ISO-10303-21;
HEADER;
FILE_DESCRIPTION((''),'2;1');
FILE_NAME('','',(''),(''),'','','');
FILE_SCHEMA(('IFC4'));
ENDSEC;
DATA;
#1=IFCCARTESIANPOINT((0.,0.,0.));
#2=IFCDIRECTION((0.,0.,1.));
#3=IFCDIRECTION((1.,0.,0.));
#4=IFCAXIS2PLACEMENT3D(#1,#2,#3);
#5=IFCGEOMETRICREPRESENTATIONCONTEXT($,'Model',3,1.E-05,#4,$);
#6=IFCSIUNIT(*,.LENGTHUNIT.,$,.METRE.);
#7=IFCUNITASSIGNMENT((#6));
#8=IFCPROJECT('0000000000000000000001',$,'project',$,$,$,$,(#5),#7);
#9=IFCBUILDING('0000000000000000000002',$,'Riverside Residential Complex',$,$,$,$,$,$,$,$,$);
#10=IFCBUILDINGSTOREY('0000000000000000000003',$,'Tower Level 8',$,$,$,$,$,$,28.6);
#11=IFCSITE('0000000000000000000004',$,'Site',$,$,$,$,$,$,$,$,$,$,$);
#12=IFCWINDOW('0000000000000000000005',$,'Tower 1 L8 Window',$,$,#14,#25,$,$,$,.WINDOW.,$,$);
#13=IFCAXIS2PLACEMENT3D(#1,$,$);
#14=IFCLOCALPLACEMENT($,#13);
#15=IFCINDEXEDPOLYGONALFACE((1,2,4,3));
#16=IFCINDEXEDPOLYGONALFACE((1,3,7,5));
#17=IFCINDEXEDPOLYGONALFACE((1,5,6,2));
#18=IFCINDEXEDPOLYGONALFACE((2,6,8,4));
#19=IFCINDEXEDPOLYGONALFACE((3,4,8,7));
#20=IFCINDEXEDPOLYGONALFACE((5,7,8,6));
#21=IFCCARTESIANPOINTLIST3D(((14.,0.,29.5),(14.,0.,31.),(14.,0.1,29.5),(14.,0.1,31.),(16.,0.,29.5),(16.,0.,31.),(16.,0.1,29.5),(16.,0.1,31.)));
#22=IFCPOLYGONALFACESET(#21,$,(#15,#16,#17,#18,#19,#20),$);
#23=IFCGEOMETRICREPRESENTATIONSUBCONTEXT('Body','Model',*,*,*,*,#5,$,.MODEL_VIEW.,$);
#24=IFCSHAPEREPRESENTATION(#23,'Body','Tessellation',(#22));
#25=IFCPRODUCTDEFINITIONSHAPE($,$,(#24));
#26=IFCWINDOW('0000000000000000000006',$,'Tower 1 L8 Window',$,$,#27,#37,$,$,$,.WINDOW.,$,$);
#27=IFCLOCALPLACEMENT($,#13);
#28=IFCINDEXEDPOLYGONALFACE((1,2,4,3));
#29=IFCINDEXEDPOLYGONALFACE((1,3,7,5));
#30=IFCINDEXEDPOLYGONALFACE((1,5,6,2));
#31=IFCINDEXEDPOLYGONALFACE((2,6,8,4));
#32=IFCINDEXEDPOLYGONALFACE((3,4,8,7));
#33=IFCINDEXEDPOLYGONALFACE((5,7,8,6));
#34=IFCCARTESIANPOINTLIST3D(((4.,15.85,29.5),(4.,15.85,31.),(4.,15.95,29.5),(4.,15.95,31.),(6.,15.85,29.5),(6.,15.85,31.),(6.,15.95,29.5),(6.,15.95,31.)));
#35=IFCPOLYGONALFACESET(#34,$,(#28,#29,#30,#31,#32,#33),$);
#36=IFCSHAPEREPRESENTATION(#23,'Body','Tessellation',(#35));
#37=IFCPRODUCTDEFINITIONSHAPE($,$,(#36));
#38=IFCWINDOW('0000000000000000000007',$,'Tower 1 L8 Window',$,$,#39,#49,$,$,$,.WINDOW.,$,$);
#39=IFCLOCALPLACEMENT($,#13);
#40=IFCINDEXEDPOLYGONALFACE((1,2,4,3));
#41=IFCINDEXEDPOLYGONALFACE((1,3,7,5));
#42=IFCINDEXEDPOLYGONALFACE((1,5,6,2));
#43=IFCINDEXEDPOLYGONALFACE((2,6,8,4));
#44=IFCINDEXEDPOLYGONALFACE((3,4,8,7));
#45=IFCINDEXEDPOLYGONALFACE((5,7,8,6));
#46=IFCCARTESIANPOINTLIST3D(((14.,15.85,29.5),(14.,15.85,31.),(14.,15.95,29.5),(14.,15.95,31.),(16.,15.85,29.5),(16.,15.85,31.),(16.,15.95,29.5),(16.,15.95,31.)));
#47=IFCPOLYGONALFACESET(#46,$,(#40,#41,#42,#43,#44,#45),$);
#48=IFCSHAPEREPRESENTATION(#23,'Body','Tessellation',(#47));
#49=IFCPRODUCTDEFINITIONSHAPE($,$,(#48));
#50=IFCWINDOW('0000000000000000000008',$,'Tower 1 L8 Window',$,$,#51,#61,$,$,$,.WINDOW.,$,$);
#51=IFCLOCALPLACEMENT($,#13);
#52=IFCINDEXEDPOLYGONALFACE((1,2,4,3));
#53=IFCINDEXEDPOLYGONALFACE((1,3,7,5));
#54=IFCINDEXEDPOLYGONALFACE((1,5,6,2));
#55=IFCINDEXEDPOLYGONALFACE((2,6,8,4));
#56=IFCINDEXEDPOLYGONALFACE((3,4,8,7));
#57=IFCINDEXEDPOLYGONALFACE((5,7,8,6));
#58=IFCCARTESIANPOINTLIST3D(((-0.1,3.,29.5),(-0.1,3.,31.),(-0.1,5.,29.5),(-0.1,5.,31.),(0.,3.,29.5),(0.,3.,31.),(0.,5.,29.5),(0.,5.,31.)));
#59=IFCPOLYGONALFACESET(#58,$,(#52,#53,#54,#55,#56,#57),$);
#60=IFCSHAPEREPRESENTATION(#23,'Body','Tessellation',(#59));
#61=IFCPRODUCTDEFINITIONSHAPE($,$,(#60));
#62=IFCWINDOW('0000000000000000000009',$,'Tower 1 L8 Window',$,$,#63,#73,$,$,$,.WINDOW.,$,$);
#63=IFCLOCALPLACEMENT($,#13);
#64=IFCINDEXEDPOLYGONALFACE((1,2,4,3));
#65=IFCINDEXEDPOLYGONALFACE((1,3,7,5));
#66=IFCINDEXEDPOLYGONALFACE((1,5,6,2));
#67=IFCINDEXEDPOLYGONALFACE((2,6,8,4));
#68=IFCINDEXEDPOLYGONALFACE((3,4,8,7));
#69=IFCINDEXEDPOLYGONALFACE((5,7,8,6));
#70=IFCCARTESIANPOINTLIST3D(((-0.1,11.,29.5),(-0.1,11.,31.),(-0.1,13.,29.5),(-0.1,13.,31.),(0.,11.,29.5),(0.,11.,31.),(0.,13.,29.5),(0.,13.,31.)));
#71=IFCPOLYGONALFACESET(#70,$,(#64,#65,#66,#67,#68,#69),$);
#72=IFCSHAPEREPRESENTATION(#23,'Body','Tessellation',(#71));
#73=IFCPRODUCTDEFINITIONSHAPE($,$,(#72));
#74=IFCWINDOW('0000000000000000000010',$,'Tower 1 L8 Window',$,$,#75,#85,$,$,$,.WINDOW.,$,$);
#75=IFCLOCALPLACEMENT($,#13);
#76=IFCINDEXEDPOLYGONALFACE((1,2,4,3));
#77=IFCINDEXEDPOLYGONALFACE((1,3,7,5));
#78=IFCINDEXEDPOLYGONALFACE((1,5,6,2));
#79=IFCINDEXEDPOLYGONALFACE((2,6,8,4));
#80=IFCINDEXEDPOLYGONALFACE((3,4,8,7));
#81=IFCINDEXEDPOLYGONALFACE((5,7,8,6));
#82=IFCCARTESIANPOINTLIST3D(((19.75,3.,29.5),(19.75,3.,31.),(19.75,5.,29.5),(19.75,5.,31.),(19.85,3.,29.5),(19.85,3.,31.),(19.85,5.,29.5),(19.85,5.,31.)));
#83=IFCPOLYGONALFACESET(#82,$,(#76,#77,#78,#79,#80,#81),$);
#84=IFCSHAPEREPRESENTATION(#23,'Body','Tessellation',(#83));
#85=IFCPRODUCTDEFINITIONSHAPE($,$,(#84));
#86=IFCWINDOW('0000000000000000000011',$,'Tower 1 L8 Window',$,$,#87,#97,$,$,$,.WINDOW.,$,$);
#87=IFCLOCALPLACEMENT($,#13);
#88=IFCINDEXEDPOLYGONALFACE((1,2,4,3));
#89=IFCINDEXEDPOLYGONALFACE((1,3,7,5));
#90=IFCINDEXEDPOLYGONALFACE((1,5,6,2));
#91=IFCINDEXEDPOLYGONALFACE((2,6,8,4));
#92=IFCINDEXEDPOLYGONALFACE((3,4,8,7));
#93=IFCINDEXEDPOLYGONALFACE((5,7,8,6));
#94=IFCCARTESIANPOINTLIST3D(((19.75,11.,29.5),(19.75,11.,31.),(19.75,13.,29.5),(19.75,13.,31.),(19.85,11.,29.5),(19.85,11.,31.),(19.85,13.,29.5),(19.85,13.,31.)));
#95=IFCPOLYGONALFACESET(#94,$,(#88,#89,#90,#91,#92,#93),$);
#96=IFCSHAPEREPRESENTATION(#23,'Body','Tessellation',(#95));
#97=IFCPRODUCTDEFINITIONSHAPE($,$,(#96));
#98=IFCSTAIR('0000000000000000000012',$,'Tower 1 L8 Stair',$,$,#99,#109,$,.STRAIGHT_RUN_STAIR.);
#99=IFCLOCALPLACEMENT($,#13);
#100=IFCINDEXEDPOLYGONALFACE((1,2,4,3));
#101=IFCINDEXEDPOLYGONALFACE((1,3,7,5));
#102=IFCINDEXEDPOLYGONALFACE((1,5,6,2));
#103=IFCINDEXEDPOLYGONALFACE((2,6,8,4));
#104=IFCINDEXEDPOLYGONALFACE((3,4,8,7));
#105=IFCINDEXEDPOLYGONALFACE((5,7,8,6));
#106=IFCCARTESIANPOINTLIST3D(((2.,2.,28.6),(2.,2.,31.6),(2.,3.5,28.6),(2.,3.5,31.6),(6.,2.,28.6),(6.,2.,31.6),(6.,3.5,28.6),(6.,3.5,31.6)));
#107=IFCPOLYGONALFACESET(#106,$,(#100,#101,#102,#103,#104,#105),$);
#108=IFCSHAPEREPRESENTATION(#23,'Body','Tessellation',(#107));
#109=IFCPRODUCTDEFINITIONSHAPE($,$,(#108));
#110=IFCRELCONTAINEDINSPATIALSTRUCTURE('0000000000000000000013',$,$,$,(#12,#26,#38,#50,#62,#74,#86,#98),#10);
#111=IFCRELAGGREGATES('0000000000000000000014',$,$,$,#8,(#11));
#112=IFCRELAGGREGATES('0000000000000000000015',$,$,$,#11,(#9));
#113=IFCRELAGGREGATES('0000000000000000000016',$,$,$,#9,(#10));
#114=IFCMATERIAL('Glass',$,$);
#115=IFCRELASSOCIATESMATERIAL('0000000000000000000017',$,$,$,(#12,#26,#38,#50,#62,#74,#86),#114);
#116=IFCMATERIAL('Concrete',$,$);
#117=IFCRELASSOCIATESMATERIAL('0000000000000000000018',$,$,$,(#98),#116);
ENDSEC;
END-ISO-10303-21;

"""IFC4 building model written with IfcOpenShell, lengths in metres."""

from ifc_helpers import new_model, si_unit, frame, origin_with_axes, place, context, subcontext, project, spatial, line, indexed_curve, outline, extrude, material, element, save


model = new_model("IFC4")

# Units and contexts
model_context = context("Model", 3, precision=1e-05, world=origin_with_axes())
body_context = subcontext(model_context, "Body", "Model", "MODEL_VIEW")
ifc_project = project(units=[si_unit("LENGTHUNIT", "METRE")], contexts=[model_context])

# Site, building, storey
site = spatial("IfcSite", under=ifc_project, Name="Site")
building = spatial("IfcBuilding", under=site, Name="Riverside Residential Complex")
storey = spatial("IfcBuildingStorey", under=building, Name="Tower Level 8", Elevation=28.6)

# Shared definitions
ifc_material_1 = material(Name="Concrete")

# Windows
ifc_material_2 = material(Name="Glass")
for number, where, z_axis, x_axis, name in (
    (1, (14.0, 0.0, 29.5), (0.0, 0.0, 1.0), (1.0, 0.0, 0.0), "Tower 1 L8 Window"),
    (2, (4.0, 15.85, 29.5), (0.0, 0.0, 1.0), (1.0, 0.0, 0.0), "Tower 1 L8 Window"),
    (3, (14.0, 15.85, 29.5), (0.0, 0.0, 1.0), (1.0, 0.0, 0.0), "Tower 1 L8 Window"),
    (4, (0.0, 3.0, 29.5), (0.0, 0.0, 1.0), (0.0, 1.0, 0.0), "Tower 1 L8 Window"),
    (5, (0.0, 11.0, 29.5), (0.0, 0.0, 1.0), (0.0, 1.0, 0.0), "Tower 1 L8 Window"),
    (6, (19.85, 3.0, 29.5), (0.0, 0.0, 1.0), (0.0, 1.0, 0.0), "Tower 1 L8 Window"),
    (7, (19.85, 11.0, 29.5), (0.0, 0.0, 1.0), (0.0, 1.0, 0.0), "Tower 1 L8 Window"),
):
    element("IfcWindow", number, at=place(None, frame(where, z_axis=z_axis, x_axis=x_axis)), inside=storey, material=ifc_material_2, Name=name, PredefinedType="WINDOW", context=body_context, shape_type="SweptSolid", body=[
        extrude(outline(indexed_curve([(0.0, 0.0), (2.0, 0.0), (2.0, 0.1), (0.0, 0.1)], segments=[line(1, 2, 3, 4, 1)])), origin_with_axes(), (0.0, 0.0, 1.0), 1.5),
    ])

# Stair
stair_placement = place(None, frame((2.0, 2.0, 28.6), z_axis=(0.0, 0.0, 1.0), x_axis=(1.0, 0.0, 0.0)))
element("IfcStair", 8, at=stair_placement, inside=storey, material=ifc_material_1, Name="Tower 1 L8 Stair", PredefinedType="STRAIGHT_RUN_STAIR", context=body_context, shape_type="SweptSolid", body=[
    extrude(outline(indexed_curve([(0.0, 0.0), (4.0, 0.0), (4.0, 1.5), (0.0, 1.5)], segments=[line(1, 2, 3, 4, 1)])), origin_with_axes(), (0.0, 0.0, 1.0), 3.0),
])

save(model, "model.ifc")
